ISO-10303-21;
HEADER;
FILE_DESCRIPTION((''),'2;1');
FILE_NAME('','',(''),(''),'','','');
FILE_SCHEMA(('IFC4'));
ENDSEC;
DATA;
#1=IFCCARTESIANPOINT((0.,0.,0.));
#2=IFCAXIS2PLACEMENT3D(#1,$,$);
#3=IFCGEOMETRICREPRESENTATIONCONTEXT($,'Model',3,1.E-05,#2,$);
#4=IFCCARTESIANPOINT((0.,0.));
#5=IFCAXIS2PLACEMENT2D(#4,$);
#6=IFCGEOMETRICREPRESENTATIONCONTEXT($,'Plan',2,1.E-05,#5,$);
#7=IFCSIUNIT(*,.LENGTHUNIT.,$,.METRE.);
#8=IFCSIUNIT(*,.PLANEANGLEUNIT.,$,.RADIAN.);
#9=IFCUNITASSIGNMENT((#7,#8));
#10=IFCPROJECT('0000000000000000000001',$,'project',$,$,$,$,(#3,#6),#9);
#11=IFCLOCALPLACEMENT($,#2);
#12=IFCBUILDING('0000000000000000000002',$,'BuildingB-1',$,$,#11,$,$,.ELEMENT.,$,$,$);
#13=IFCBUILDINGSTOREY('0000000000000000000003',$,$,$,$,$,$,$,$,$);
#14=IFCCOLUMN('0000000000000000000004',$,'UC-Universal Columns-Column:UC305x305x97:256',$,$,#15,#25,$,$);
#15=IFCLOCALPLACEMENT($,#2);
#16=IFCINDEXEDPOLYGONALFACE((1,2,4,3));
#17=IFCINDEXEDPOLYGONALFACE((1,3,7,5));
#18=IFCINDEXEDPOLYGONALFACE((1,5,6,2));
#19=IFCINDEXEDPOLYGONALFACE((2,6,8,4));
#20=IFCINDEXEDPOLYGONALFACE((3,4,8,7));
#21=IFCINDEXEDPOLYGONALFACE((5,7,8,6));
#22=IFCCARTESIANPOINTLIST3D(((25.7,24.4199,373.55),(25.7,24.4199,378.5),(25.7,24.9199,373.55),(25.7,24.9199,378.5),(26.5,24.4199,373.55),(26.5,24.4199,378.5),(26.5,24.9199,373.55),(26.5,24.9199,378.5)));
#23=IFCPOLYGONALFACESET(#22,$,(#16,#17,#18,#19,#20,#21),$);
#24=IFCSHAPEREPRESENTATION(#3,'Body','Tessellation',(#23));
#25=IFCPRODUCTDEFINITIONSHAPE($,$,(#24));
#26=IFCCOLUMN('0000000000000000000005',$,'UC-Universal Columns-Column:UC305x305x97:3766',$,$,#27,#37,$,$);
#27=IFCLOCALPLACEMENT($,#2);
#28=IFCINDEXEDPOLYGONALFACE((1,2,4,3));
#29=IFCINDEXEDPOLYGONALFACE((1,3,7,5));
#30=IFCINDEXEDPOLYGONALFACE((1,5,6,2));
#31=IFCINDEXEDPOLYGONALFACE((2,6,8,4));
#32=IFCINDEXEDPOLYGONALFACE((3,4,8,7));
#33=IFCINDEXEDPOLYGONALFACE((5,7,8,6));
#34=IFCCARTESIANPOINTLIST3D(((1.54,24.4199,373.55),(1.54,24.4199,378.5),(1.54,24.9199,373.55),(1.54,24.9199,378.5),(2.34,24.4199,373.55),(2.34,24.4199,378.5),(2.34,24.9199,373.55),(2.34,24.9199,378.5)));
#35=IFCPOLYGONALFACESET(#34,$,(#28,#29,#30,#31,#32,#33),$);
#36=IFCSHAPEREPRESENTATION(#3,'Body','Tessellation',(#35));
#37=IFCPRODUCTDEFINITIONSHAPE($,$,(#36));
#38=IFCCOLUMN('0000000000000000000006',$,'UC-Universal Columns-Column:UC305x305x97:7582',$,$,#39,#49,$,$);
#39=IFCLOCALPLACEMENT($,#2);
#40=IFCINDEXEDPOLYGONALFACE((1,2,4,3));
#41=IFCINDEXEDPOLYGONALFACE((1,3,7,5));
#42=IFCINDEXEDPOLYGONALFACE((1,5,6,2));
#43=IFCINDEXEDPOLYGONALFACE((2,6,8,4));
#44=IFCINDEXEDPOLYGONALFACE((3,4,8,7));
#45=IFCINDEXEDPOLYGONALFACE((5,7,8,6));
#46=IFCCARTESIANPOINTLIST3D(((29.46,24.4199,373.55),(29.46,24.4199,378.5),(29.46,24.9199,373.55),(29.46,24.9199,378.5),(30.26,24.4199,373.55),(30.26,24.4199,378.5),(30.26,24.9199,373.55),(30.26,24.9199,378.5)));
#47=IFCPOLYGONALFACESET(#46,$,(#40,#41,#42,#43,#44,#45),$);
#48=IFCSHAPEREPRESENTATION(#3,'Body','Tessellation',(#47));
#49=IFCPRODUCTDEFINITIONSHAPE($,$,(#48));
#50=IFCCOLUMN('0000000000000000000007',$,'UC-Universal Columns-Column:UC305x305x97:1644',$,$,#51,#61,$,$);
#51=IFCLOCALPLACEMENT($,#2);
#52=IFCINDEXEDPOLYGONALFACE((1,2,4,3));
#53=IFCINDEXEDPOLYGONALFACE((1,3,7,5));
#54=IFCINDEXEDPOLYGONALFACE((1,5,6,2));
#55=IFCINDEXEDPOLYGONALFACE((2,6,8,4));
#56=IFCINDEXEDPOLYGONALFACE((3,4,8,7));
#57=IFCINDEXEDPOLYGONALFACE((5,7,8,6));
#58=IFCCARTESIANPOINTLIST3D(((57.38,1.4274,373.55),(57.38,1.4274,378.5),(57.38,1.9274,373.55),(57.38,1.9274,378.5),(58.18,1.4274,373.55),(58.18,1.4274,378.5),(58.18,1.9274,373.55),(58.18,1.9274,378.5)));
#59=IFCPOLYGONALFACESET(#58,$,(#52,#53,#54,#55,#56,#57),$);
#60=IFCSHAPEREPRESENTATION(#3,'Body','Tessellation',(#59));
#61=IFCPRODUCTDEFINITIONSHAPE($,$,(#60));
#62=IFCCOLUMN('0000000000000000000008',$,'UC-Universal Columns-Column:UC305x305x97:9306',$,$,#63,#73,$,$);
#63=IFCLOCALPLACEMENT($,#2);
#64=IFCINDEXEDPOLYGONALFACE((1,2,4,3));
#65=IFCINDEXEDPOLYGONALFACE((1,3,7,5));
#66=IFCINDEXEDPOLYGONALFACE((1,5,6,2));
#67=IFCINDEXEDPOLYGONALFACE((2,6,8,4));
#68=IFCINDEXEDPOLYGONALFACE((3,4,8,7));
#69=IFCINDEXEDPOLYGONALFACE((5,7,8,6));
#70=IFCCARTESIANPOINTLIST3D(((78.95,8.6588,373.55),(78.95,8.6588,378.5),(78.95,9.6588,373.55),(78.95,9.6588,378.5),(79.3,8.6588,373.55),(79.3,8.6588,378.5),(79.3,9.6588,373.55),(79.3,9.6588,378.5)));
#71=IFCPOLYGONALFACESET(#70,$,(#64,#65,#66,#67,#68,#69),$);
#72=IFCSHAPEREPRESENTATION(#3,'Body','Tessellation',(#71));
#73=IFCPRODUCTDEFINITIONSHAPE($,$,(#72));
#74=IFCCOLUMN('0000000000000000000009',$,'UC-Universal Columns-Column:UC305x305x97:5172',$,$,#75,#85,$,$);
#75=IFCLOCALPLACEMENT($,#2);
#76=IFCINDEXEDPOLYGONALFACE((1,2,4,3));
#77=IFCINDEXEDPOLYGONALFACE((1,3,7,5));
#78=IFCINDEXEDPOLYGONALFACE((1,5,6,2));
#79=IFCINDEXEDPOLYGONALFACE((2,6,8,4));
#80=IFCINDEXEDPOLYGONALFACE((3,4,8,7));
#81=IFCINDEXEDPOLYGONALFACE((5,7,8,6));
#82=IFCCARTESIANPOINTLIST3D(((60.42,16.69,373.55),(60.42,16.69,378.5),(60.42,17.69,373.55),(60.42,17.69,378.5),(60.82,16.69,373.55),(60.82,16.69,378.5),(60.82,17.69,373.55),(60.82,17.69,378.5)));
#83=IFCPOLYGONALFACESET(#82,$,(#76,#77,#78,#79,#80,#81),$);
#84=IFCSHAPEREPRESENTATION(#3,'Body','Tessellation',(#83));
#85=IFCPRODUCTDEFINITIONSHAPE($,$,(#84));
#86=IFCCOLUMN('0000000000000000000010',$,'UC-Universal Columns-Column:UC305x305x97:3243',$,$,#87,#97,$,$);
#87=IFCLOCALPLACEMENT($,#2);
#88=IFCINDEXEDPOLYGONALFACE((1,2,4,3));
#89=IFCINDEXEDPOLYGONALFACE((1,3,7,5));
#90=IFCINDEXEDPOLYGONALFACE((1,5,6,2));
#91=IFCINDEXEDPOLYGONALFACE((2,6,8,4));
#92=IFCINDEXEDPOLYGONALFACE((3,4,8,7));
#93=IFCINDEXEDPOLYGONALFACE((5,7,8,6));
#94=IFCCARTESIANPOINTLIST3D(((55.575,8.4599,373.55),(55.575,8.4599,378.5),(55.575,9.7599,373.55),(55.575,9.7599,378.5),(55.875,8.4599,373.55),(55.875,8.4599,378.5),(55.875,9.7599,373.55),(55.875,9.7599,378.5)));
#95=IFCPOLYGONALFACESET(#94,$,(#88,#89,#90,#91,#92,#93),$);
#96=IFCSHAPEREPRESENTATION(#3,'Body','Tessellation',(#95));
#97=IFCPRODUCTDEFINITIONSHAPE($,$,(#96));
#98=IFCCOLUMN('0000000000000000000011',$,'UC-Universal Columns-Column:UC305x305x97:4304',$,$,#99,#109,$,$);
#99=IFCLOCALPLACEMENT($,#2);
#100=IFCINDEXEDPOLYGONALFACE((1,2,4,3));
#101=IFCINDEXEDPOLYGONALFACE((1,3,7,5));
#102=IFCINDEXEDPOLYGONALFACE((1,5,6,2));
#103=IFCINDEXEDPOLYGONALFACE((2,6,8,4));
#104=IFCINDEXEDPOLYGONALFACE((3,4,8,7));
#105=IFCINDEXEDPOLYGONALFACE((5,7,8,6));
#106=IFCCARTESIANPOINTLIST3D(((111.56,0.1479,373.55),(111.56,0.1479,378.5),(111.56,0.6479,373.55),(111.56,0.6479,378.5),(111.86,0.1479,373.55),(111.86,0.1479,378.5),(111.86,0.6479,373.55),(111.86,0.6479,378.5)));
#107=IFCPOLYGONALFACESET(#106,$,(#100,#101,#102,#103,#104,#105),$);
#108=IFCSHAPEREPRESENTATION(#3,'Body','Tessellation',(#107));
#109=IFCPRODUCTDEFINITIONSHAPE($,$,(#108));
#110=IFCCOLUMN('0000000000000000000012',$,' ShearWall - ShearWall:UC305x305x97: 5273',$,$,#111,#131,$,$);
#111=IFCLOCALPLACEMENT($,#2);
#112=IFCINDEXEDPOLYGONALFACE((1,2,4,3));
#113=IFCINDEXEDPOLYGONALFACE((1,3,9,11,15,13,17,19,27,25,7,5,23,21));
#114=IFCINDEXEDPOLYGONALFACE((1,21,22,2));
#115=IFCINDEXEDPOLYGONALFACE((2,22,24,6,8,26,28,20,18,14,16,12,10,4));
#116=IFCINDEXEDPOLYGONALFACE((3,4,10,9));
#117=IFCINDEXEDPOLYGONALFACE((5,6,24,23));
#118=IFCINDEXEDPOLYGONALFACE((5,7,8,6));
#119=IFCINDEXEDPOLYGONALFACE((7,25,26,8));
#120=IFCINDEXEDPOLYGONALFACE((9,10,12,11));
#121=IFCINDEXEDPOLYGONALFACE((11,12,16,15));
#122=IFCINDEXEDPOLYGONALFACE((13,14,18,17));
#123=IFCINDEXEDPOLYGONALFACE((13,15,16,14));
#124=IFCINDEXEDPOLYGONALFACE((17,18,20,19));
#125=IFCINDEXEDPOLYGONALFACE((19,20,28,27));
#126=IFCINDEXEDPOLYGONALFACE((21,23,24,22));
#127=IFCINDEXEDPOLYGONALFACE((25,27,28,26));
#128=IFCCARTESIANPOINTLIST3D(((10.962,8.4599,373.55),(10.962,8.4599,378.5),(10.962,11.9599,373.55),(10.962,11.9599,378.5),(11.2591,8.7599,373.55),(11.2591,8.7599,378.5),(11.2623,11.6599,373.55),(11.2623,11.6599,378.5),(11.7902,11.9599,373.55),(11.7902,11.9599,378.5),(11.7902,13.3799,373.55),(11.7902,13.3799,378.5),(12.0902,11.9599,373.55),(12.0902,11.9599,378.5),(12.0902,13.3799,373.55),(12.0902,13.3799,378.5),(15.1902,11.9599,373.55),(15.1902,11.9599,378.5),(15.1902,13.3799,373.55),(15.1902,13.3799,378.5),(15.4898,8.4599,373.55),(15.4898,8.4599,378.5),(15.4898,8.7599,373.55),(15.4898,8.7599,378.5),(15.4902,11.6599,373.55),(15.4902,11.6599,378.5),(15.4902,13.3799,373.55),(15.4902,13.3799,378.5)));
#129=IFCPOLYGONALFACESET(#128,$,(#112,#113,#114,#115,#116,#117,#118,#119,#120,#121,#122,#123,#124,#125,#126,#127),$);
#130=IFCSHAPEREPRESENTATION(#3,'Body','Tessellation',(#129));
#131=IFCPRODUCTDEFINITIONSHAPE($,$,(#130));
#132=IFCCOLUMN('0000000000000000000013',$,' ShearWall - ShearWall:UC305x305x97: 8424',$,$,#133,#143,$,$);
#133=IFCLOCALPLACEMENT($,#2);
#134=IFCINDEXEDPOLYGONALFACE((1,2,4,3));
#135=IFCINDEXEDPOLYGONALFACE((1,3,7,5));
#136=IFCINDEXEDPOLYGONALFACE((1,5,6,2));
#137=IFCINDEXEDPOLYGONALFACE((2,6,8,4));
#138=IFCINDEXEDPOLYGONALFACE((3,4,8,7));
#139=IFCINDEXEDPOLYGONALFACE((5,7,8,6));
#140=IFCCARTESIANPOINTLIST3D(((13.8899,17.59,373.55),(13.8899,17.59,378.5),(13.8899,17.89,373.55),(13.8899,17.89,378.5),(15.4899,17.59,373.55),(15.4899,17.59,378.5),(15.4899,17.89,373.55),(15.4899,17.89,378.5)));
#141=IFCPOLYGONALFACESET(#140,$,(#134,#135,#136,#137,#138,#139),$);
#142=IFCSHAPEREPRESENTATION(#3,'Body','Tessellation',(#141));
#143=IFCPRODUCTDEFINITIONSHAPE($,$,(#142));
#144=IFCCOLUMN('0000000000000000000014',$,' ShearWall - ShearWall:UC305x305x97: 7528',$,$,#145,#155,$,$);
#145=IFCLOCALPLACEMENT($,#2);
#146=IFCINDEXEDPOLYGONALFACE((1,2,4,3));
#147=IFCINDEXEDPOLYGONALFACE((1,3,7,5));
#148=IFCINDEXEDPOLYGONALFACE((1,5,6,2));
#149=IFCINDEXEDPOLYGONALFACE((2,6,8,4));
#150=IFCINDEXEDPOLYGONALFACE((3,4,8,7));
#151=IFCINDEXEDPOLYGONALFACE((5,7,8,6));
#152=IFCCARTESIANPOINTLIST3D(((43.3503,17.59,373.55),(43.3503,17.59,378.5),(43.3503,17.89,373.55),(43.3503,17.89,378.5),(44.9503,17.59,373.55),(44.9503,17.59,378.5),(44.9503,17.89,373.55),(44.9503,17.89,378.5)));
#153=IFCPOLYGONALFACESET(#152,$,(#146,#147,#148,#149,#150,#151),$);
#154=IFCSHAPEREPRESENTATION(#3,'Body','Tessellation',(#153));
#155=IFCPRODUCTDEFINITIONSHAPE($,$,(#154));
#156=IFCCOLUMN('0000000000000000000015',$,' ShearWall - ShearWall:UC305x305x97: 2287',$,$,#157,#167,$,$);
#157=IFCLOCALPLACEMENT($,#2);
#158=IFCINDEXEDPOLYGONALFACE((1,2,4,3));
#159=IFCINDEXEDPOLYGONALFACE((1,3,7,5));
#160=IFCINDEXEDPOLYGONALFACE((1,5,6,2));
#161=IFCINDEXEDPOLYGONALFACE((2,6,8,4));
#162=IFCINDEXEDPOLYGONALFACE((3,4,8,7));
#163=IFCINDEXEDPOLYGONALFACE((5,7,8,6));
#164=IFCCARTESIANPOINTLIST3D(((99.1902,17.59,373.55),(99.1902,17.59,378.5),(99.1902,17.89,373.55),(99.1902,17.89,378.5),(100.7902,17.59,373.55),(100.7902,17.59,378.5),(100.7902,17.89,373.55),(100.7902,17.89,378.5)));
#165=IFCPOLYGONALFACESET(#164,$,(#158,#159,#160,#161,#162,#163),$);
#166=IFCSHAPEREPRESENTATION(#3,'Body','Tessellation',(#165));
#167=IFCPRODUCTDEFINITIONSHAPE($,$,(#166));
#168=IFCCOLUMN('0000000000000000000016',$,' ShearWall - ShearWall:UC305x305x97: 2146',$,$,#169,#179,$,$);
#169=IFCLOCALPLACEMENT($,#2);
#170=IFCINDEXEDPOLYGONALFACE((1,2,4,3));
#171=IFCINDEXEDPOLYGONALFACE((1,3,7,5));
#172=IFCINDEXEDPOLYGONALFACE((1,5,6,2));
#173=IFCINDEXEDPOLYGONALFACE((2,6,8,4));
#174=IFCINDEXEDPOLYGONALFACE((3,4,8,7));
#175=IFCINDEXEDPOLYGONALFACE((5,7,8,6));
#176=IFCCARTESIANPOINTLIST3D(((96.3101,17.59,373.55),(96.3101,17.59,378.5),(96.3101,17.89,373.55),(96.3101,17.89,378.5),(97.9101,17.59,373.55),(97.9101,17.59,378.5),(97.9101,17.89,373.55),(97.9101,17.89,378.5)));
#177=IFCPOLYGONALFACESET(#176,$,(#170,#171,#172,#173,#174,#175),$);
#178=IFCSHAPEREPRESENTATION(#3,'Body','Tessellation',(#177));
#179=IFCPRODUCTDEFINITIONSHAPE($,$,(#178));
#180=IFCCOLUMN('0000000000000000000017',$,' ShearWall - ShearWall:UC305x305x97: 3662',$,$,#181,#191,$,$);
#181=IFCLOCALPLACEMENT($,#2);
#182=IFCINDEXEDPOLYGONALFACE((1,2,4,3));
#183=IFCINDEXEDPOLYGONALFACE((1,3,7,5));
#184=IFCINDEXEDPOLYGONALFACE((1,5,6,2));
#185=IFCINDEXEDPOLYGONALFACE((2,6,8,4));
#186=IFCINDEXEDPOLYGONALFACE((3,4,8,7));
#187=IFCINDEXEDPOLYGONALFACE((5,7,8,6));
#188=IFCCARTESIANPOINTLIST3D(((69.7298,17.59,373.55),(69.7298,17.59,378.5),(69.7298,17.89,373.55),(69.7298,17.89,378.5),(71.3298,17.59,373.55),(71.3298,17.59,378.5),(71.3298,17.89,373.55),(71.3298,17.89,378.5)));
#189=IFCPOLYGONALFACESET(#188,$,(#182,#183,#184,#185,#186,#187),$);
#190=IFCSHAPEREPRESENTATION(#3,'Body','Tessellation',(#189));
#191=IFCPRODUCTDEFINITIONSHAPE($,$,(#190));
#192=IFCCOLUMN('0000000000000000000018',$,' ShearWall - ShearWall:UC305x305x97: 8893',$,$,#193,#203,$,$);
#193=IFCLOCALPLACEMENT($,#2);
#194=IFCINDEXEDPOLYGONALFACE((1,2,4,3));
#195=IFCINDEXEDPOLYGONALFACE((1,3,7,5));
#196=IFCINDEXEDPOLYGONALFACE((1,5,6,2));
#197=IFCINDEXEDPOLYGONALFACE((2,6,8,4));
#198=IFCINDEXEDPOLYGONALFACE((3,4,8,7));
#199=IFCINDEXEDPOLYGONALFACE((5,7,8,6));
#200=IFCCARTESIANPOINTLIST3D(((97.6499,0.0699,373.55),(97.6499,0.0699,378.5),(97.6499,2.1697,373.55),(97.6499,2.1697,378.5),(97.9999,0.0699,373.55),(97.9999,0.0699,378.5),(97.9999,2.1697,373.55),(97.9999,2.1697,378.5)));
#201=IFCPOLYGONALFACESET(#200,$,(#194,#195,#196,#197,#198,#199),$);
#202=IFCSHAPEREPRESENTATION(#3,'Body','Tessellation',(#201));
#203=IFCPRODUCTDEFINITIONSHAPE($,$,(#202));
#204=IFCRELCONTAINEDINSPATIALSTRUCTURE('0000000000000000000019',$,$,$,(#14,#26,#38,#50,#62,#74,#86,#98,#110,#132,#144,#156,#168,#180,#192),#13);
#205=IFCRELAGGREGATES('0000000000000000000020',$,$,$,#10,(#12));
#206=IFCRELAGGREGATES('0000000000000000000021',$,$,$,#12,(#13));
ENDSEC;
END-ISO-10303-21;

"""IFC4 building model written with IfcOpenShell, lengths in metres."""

from ifc_helpers import new_model, si_unit, origin, origin_with_axes, origin_2d, place, context, project, spatial, polyline, outline, extrude, element, save


model = new_model("IFC4")

# Units and contexts
model_context = context("Model", 3, precision=1e-05, world=origin())
plan_context = context("Plan", 2, precision=1e-05, world=origin_2d())
ifc_project = project(units=[si_unit("LENGTHUNIT", "METRE"), si_unit("PLANEANGLEUNIT", "RADIAN")], contexts=[model_context, plan_context])

# Building, storey
building_placement = place(None, origin())
building = spatial("IfcBuilding", under=ifc_project, at=building_placement, Name="BuildingB-1", CompositionType="ELEMENT")
storey = spatial("IfcBuildingStorey", under=building)

# Columns
element("IfcColumn", 1, inside=storey, Name="UC-Universal Columns-Column:UC305x305x97:256", context=model_context, shape_type="SweptSolid", body=[
    extrude(outline(polyline([(25.7, 24.4199, 378.5), (26.5, 24.4199, 378.5), (26.5, 24.9199, 378.5), (25.7, 24.9199, 378.5), (25.7, 24.4199, 378.5)])), None, (0.0, 0.0, -1.0), 4.95),
])
element("IfcColumn", 2, inside=storey, Name="UC-Universal Columns-Column:UC305x305x97:3766", context=model_context, shape_type="SweptSolid", body=[
    extrude(outline(polyline([(1.54, 24.4199, 378.5), (2.34, 24.4199, 378.5), (2.34, 24.9199, 378.5), (1.54, 24.9199, 378.5), (1.54, 24.4199, 378.5)])), None, (0.0, 0.0, -1.0), 4.95),
])
element("IfcColumn", 3, inside=storey, Name="UC-Universal Columns-Column:UC305x305x97:7582", context=model_context, shape_type="SweptSolid", body=[
    extrude(outline(polyline([(30.26, 24.4199, 378.5), (29.46, 24.4199, 378.5), (29.46, 24.9199, 378.5), (30.26, 24.9199, 378.5), (30.26, 24.4199, 378.5)])), None, (0.0, 0.0, -1.0), 4.95),
])
element("IfcColumn", 4, inside=storey, Name="UC-Universal Columns-Column:UC305x305x97:1644", context=model_context, shape_type="SweptSolid", body=[
    extrude(outline(polyline([(57.38, 1.4274, 378.5), (58.18, 1.4274, 378.5), (58.18, 1.9274, 378.5), (57.38, 1.9274, 378.5), (57.38, 1.4274, 378.5)])), None, (0.0, 0.0, -1.0), 4.95),
])
element("IfcColumn", 5, inside=storey, Name="UC-Universal Columns-Column:UC305x305x97:9306", context=model_context, shape_type="SweptSolid", body=[
    extrude(outline(polyline([(79.3, 8.6588, 378.5), (78.95, 8.6588, 378.5), (78.95, 9.6588, 378.5), (79.3, 9.6588, 378.5), (79.3, 8.6588, 378.5)])), None, (0.0, 0.0, -1.0), 4.95),
])
element("IfcColumn", 6, inside=storey, Name="UC-Universal Columns-Column:UC305x305x97:5172", context=model_context, shape_type="SweptSolid", body=[
    extrude(outline(polyline([(60.42, 17.69, 378.5), (60.82, 17.69, 378.5), (60.82, 16.69, 378.5), (60.42, 16.69, 378.5), (60.42, 17.69, 378.5)])), None, (0.0, 0.0, -1.0), 4.95),
])
element("IfcColumn", 7, inside=storey, Name="UC-Universal Columns-Column:UC305x305x97:3243", context=model_context, shape_type="SweptSolid", body=[
    extrude(outline(polyline([(55.575, 9.7599, 378.5), (55.575, 8.4599, 378.5), (55.875, 8.4599, 378.5), (55.875, 9.7599, 378.5), (55.575, 9.7599, 378.5)])), None, (0.0, 0.0, -1.0), 4.95),
])
element("IfcColumn", 8, inside=storey, Name="UC-Universal Columns-Column:UC305x305x97:4304", context=model_context, shape_type="SweptSolid", body=[
    extrude(outline(polyline([(111.56, 0.6479, 378.5), (111.86, 0.6479, 378.5), (111.86, 0.1479, 378.5), (111.56, 0.1479, 378.5), (111.56, 0.6479, 378.5)])), None, (0.0, 0.0, -1.0), 4.95),
])
column_1_placement = place(None, origin_with_axes())
element("IfcColumn", 9, at=column_1_placement, inside=storey, Name=" ShearWall - ShearWall:UC305x305x97: 5273", context=model_context, shape_type="SweptSolid", body=[
    extrude(outline(polyline([(10.962, 8.4599, 378.5), (15.4898, 8.4599, 378.5), (15.4898, 8.7599, 378.5), (11.2591, 8.7599, 378.5), (11.2623, 11.6599, 378.5), (15.4902, 11.6599, 378.5), (15.4902, 13.3799, 378.5), (15.1902, 13.3799, 378.5), (15.1902, 11.9599, 378.5), (12.0902, 11.9599, 378.5), (12.0902, 13.3799, 378.5), (11.7902, 13.3799, 378.5), (11.7902, 11.9599, 378.5), (10.962, 11.9599, 378.5), (10.962, 8.4599, 378.5)])), None, (0.0, 0.0, -1.0), 4.95),
])
column_2_placement = place(None, origin_with_axes())
element("IfcColumn", 10, at=column_2_placement, inside=storey, Name=" ShearWall - ShearWall:UC305x305x97: 8424", context=model_context, shape_type="SweptSolid", body=[
    extrude(outline(polyline([(13.8899, 17.59, 378.5), (13.8899, 17.89, 378.5), (15.4899, 17.89, 378.5), (15.4899, 17.59, 378.5), (13.8899, 17.59, 378.5)])), None, (0.0, 0.0, -1.0), 4.95),
])
column_3_placement = place(None, origin_with_axes())
element("IfcColumn", 11, at=column_3_placement, inside=storey, Name=" ShearWall - ShearWall:UC305x305x97: 7528", context=model_context, shape_type="SweptSolid", body=[
    extrude(outline(polyline([(44.9503, 17.59, 378.5), (44.9503, 17.89, 378.5), (43.3503, 17.89, 378.5), (43.3503, 17.59, 378.5), (44.9503, 17.59, 378.5)])), None, (0.0, 0.0, -1.0), 4.95),
])
column_4_placement = place(None, origin_with_axes())
element("IfcColumn", 12, at=column_4_placement, inside=storey, Name=" ShearWall - ShearWall:UC305x305x97: 2287", context=model_context, shape_type="SweptSolid", body=[
    extrude(outline(polyline([(100.7902, 17.59, 378.5), (100.7902, 17.89, 378.5), (99.1902, 17.89, 378.5), (99.1902, 17.59, 378.5), (100.7902, 17.59, 378.5)])), None, (0.0, 0.0, -1.0), 4.95),
])
column_5_placement = place(None, origin_with_axes())
element("IfcColumn", 13, at=column_5_placement, inside=storey, Name=" ShearWall - ShearWall:UC305x305x97: 2146", context=model_context, shape_type="SweptSolid", body=[
    extrude(outline(polyline([(97.9101, 17.59, 378.5), (97.9101, 17.89, 378.5), (96.3101, 17.89, 378.5), (96.3101, 17.59, 378.5), (97.9101, 17.59, 378.5)])), None, (0.0, 0.0, -1.0), 4.95),
])
column_6_placement = place(None, origin_with_axes())
element("IfcColumn", 14, at=column_6_placement, inside=storey, Name=" ShearWall - ShearWall:UC305x305x97: 3662", context=model_context, shape_type="SweptSolid", body=[
    extrude(outline(polyline([(69.7298, 17.59, 378.5), (69.7298, 17.89, 378.5), (71.3298, 17.89, 378.5), (71.3298, 17.59, 378.5), (69.7298, 17.59, 378.5)])), None, (0.0, 0.0, -1.0), 4.95),
])
column_7_placement = place(None, origin_with_axes())
element("IfcColumn", 15, at=column_7_placement, inside=storey, Name=" ShearWall - ShearWall:UC305x305x97: 8893", context=model_context, shape_type="SweptSolid", body=[
    extrude(outline(polyline([(97.6499, 2.1697, 378.5), (97.9999, 2.1697, 378.5), (97.9999, 0.0699, 378.5), (97.6499, 0.0699, 378.5), (97.6499, 2.1697, 378.5)])), None, (0.0, 0.0, -1.0), 4.95),
])

save(model, "model.ifc")
